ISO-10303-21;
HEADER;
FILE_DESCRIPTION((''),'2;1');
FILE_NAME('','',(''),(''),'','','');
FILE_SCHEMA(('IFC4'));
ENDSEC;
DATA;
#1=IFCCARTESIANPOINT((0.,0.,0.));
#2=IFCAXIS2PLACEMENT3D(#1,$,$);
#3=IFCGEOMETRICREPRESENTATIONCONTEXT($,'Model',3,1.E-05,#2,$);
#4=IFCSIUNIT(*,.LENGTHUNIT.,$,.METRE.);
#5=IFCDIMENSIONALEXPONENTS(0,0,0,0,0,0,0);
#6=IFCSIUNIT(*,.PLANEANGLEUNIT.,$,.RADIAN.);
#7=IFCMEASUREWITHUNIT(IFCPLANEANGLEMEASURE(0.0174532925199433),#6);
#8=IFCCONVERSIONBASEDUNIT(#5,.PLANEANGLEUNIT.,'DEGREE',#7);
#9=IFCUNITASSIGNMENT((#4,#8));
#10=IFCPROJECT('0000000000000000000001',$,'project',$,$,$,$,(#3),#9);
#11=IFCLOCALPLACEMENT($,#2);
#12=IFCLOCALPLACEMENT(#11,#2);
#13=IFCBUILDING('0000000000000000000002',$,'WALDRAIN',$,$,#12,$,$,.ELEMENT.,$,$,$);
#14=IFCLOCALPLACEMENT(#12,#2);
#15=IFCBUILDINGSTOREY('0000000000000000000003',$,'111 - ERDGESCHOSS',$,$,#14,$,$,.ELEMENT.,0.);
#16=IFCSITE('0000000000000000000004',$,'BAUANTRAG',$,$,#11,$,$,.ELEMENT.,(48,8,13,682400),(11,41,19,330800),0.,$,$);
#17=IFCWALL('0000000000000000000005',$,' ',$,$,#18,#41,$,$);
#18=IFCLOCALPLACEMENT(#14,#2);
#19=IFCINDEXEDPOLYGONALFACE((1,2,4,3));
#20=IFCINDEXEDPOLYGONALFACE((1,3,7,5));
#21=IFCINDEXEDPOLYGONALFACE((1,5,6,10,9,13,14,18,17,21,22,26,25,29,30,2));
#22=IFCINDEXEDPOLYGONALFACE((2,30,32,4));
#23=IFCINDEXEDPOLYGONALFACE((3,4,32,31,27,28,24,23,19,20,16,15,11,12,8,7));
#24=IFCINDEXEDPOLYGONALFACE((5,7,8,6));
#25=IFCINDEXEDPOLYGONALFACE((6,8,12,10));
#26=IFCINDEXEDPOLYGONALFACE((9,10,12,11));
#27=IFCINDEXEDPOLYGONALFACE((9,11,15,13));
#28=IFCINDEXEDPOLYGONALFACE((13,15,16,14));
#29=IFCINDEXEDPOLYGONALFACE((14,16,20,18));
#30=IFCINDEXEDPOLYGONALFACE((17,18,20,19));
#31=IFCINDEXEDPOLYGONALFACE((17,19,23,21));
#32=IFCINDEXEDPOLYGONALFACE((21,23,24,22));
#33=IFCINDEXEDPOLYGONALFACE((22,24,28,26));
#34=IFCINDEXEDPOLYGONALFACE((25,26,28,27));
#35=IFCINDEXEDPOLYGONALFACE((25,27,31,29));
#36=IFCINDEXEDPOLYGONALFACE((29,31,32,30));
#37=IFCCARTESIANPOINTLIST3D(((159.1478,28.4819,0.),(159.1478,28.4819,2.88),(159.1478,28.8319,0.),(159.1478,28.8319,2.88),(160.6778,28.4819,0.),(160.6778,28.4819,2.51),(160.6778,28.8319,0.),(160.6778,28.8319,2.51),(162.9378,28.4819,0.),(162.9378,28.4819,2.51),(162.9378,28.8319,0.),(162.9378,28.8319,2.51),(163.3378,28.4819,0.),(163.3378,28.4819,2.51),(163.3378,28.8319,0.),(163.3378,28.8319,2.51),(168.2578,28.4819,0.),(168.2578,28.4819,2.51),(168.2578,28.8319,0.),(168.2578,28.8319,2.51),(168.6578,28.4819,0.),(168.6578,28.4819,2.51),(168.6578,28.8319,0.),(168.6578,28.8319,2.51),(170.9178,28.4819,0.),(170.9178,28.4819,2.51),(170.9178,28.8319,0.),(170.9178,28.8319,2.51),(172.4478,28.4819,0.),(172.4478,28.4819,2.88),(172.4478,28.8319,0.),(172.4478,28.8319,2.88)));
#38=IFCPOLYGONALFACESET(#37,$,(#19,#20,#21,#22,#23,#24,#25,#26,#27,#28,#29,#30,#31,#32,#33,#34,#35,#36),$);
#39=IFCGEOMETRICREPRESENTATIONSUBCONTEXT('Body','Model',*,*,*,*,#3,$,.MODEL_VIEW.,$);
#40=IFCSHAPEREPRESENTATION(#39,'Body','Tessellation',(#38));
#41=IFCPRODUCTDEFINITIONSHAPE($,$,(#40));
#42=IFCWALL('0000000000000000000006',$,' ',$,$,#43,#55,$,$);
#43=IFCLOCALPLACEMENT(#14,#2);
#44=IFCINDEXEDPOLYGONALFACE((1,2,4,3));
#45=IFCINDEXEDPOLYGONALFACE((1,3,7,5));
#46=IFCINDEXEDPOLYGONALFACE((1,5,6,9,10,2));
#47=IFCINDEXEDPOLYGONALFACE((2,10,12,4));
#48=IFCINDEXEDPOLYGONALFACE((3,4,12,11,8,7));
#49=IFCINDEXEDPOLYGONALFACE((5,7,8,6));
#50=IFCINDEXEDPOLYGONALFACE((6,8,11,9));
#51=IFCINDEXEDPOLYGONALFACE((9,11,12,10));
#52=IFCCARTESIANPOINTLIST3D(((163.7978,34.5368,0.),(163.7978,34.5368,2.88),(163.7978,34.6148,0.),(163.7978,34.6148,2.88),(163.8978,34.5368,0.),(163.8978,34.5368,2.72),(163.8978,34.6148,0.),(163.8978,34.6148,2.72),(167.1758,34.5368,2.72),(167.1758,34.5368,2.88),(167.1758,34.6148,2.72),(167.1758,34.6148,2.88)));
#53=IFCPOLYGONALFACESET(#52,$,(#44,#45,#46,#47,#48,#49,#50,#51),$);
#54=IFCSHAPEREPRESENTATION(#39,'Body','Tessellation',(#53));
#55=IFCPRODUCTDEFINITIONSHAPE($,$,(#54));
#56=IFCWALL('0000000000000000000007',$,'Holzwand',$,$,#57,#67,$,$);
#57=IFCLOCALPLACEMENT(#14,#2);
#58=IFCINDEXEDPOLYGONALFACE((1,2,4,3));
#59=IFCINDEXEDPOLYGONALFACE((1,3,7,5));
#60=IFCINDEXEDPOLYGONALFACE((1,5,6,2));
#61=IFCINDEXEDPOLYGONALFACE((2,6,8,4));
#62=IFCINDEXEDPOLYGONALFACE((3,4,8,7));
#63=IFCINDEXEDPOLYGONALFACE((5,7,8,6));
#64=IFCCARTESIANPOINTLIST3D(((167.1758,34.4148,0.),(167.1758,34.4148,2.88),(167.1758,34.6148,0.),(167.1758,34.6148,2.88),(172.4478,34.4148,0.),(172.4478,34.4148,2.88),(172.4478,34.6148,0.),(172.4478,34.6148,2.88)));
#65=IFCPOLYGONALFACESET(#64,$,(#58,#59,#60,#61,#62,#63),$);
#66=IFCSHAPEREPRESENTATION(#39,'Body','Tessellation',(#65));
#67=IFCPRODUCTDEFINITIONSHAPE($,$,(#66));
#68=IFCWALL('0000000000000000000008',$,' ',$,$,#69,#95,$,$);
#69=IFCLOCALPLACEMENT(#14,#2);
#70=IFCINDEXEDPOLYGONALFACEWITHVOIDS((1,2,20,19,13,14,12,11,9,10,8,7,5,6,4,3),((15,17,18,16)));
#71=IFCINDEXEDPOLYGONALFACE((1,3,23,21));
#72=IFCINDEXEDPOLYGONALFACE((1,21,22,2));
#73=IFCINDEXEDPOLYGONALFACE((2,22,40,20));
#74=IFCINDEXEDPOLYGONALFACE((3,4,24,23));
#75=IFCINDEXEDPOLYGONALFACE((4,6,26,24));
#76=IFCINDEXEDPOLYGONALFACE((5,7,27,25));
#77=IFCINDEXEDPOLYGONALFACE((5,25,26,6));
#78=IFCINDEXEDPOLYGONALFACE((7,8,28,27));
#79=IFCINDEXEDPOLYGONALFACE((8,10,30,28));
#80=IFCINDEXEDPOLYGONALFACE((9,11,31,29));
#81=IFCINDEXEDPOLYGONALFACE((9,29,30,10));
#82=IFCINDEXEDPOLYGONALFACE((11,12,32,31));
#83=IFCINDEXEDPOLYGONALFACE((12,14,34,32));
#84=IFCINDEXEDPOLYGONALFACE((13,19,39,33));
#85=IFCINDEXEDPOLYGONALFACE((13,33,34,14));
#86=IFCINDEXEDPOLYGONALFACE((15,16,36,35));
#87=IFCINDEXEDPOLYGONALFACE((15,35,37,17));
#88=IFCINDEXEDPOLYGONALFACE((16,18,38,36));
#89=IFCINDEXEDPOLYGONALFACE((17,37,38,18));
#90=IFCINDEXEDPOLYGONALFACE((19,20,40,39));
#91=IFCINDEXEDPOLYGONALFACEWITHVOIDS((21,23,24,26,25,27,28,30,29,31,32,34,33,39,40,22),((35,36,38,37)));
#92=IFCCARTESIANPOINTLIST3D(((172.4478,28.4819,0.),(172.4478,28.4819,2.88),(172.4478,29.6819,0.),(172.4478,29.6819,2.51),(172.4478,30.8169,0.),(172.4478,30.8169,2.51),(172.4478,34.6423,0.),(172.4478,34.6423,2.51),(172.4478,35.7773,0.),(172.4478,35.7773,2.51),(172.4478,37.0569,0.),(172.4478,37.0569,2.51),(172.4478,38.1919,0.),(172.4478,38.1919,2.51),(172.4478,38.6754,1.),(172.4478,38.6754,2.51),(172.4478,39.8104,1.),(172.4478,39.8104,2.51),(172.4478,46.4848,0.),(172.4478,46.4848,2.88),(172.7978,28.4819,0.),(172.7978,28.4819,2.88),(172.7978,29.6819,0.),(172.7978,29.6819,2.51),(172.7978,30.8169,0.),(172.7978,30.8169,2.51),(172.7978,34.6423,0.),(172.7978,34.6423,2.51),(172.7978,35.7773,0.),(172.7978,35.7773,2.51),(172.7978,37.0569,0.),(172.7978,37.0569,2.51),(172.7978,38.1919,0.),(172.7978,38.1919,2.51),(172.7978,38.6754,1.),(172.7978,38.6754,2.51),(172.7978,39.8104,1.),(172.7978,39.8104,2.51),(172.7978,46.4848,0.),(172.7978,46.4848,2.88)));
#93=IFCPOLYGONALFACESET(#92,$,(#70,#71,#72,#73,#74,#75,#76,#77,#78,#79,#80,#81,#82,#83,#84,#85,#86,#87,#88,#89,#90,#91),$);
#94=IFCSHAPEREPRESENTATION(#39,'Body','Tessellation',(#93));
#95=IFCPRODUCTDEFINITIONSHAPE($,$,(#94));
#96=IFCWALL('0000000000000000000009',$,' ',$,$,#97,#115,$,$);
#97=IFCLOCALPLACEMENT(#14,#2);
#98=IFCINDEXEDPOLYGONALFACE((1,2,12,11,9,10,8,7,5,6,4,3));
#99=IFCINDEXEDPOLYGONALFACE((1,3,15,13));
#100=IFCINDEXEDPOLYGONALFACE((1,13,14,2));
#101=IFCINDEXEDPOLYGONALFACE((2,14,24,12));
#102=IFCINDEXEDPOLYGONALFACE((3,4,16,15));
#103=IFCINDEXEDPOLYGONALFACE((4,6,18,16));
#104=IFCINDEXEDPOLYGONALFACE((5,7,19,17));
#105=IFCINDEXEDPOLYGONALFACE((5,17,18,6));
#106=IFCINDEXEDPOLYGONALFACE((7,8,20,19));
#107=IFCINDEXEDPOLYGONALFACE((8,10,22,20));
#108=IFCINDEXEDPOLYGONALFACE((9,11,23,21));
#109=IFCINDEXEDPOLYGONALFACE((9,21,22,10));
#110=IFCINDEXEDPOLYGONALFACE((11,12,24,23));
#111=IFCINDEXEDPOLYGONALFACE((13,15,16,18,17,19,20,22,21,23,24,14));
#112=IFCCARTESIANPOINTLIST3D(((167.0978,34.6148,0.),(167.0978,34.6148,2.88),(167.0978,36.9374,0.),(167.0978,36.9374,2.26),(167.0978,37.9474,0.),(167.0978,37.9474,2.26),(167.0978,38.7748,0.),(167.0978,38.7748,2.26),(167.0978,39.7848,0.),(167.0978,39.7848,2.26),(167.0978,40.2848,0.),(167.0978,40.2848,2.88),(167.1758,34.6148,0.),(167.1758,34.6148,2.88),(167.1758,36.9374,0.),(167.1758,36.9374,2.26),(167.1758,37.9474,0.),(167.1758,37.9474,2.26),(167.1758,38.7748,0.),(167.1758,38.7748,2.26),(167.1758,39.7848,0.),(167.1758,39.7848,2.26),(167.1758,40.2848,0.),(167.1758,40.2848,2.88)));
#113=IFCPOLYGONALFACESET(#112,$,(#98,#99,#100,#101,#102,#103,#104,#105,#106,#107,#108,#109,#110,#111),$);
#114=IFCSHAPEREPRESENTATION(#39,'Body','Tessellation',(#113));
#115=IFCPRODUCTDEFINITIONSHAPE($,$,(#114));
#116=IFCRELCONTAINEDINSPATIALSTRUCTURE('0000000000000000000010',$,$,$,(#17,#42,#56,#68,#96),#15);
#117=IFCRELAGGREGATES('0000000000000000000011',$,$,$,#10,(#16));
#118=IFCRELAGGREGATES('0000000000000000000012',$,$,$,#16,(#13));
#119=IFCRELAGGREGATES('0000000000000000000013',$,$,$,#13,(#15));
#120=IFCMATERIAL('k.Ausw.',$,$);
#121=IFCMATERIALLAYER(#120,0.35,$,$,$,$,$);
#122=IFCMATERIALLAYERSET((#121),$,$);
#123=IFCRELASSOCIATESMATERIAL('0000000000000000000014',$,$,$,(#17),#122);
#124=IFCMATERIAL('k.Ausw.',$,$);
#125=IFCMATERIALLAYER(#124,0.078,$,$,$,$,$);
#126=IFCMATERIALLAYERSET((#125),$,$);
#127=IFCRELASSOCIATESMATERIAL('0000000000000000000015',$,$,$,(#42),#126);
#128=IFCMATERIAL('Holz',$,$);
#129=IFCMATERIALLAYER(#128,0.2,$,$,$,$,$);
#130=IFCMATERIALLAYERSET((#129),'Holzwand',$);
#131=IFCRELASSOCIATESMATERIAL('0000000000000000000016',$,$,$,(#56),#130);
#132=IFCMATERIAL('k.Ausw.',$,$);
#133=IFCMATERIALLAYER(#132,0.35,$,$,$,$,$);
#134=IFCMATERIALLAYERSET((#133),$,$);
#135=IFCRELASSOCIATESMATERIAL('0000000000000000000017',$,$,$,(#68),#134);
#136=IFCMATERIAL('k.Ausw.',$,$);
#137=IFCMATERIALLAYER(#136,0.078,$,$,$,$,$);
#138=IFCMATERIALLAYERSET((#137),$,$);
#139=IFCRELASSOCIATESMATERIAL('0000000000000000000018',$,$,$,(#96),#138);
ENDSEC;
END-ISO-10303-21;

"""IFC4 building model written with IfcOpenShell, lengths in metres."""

from ifc_helpers import new_model, entity, si_unit, converted_unit, frame, frame_2d, origin, origin_with_axes, place, context, subcontext, project, spatial, polyline, rectangle, outline, extrude, material, layer, layer_set, layer_usage, element, save


model = new_model("IFC4")

# Units and contexts
model_context = context("Model", 3, precision=1e-05, world=origin())
body_context = subcontext(model_context, "Body", "Model", "MODEL_VIEW")
ifc_project = project(units=[si_unit("LENGTHUNIT", "METRE"), converted_unit("PLANEANGLEUNIT", "DEGREE", entity("IfcPlaneAngleMeasure", 0.0174532925199433), si_unit("PLANEANGLEUNIT", "RADIAN"), dimensions=[0, 0, 0, 0, 0, 0, 0])], contexts=[model_context])

# Site, building, storey
site_placement = place(None, origin())
site = spatial("IfcSite", under=ifc_project, at=site_placement, Name="BAUANTRAG", CompositionType="ELEMENT", RefLatitude=(48, 8, 13, 682400), RefLongitude=(11, 41, 19, 330800), RefElevation=0.0)
building_placement = place(site_placement, origin())
building = spatial("IfcBuilding", under=site, at=building_placement, Name="WALDRAIN", CompositionType="ELEMENT")
storey_placement = place(building_placement, origin())
storey = spatial("IfcBuildingStorey", under=building, at=storey_placement, Name="111 - ERDGESCHOSS", CompositionType="ELEMENT", Elevation=0.0)

# Wall, openings
ifc_material_1 = material(Name="k.Ausw.")
ifc_layer_1 = layer(ifc_material_1, 0.35)
ifc_layer_set_1 = layer_set([ifc_layer_1])
ifc_layer_usage_1 = layer_usage(ifc_layer_set_1, "AXIS2", "POSITIVE", 0.0)
wall_1_placement = place(storey_placement, frame((159.1478, 28.4819, 0.0)))
wall_1 = element("IfcWall", 1, at=wall_1_placement, inside=storey, material=ifc_layer_usage_1, Name=" ", context=body_context, shape_type="SweptSolid", body=[
    extrude(rectangle(XDim=13.3, YDim=0.35, at=frame_2d((6.65, 0.175), x_axis=(1.0, 0.0))), origin_with_axes(), (0.0, 0.0, 1.0), 2.88),
])
opening_1_placement = place(wall_1_placement, frame((1.53, 0.0, 0.0), z_axis=(0.0, 1.0, 0.0), x_axis=(0.0, 0.0, 1.0)))
element("IfcOpeningElement", 2, at=opening_1_placement, cuts=wall_1, ObjectType="Opening", context=body_context, shape_type="SweptSolid", body=[
    extrude(outline(polyline([(0.0, 2.26), (2.51, 2.26), (2.51, 0.0), (0.0, 0.0), (0.0, 2.26)])), origin_with_axes(), (0.0, 0.0, 1.0), 0.35),
])
opening_2_placement = place(wall_1_placement, frame((4.19, 0.0, 0.0), z_axis=(0.0, 1.0, 0.0), x_axis=(0.0, 0.0, 1.0)))
element("IfcOpeningElement", 3, at=opening_2_placement, cuts=wall_1, ObjectType="Opening", context=body_context, shape_type="SweptSolid", body=[
    extrude(outline(polyline([(0.0, 4.92), (2.51, 4.92), (2.51, 0.0), (0.0, 0.0), (0.0, 4.92)])), origin_with_axes(), (0.0, 0.0, 1.0), 0.35),
])
opening_3_placement = place(wall_1_placement, frame((9.51, 0.0, 0.0), z_axis=(0.0, 1.0, 0.0), x_axis=(0.0, 0.0, 1.0)))
element("IfcOpeningElement", 4, at=opening_3_placement, cuts=wall_1, ObjectType="Opening", context=body_context, shape_type="SweptSolid", body=[
    extrude(outline(polyline([(0.0, 2.26), (2.51, 2.26), (2.51, 0.0), (0.0, 0.0), (0.0, 2.26)])), origin_with_axes(), (0.0, 0.0, 1.0), 0.35),
])

# Wall, opening
ifc_material_2 = material(Name="k.Ausw.")
ifc_layer_2 = layer(ifc_material_2, 0.078)
ifc_layer_set_2 = layer_set([ifc_layer_2])
ifc_layer_usage_2 = layer_usage(ifc_layer_set_2, "AXIS2", "POSITIVE", 0.0)
wall_2_placement = place(storey_placement, frame((163.7978, 34.5368, 0.0)))
wall_2 = element("IfcWall", 5, at=wall_2_placement, inside=storey, material=ifc_layer_usage_2, Name=" ", context=body_context, shape_type="SweptSolid", body=[
    extrude(rectangle(XDim=3.378, YDim=0.078, at=frame_2d((1.689, 0.039), x_axis=(1.0, 0.0))), origin_with_axes(), (0.0, 0.0, 1.0), 2.88),
])
opening_4_placement = place(wall_2_placement, frame((0.1, 0.0, 0.0), z_axis=(0.0, 1.0, 0.0), x_axis=(0.0, 0.0, 1.0)))
element("IfcOpeningElement", 6, at=opening_4_placement, cuts=wall_2, ObjectType="Opening", context=body_context, shape_type="SweptSolid", body=[
    extrude(outline(polyline([(0.0, 3.278), (2.72, 3.278), (2.72, 0.0), (0.0, 0.0), (0.0, 3.278)])), origin_with_axes(), (0.0, 0.0, 1.0), 0.078),
])

# Wall
ifc_material_3 = material(Name="Holz")
ifc_layer_3 = layer(ifc_material_3, 0.2)
ifc_layer_set_3 = layer_set([ifc_layer_3], Name="Holzwand")
ifc_layer_usage_3 = layer_usage(ifc_layer_set_3, "AXIS2", "POSITIVE", 0.0)
wall_3_placement = place(storey_placement, frame((167.1758, 34.4148, 0.0)))
element("IfcWall", 7, at=wall_3_placement, inside=storey, material=ifc_layer_usage_3, Name="Holzwand", context=body_context, shape_type="SweptSolid", body=[
    extrude(rectangle(XDim=5.272, YDim=0.2, at=frame_2d((2.636, 0.1), x_axis=(1.0, 0.0))), origin_with_axes(), (0.0, 0.0, 1.0), 2.88),
])

# Walls, openings
ifc_material_4 = material(Name="k.Ausw.")
ifc_layer_4 = layer(ifc_material_4, 0.35)
ifc_layer_set_4 = layer_set([ifc_layer_4])
ifc_layer_usage_4 = layer_usage(ifc_layer_set_4, "AXIS2", "POSITIVE", 0.0)
wall_4_placement = place(storey_placement, frame((172.7978, 28.4819, 0.0), z_axis=(0.0, 0.0, 1.0), x_axis=(0.0, 1.0, 0.0)))
wall_4 = element("IfcWall", 8, at=wall_4_placement, inside=storey, material=ifc_layer_usage_4, Name=" ", context=body_context, shape_type="SweptSolid", body=[
    extrude(rectangle(XDim=18.0029, YDim=0.35, at=frame_2d((9.0014, 0.175), x_axis=(1.0, 0.0))), origin_with_axes(), (0.0, 0.0, 1.0), 2.88),
])
opening_5_placement = place(wall_4_placement, frame((10.1935, 0.0, 1.0), z_axis=(0.0, 1.0, 0.0), x_axis=(0.0, 0.0, 1.0)))
element("IfcOpeningElement", 9, at=opening_5_placement, cuts=wall_4, ObjectType="Opening", context=body_context, shape_type="SweptSolid", body=[
    extrude(outline(polyline([(0.0, 1.135), (1.51, 1.135), (1.51, 0.0), (0.0, 0.0), (0.0, 1.135)])), origin_with_axes(), (0.0, 0.0, 1.0), 0.35),
])
opening_6_placement = place(wall_4_placement, frame((1.2, 0.0, 0.0), z_axis=(0.0, 1.0, 0.0), x_axis=(0.0, 0.0, 1.0)))
element("IfcOpeningElement", 10, at=opening_6_placement, cuts=wall_4, ObjectType="Opening", context=body_context, shape_type="SweptSolid", body=[
    extrude(outline(polyline([(0.0, 1.135), (2.51, 1.135), (2.51, 0.0), (0.0, 0.0), (0.0, 1.135)])), origin_with_axes(), (0.0, 0.0, 1.0), 0.35),
])
opening_7_placement = place(wall_4_placement, frame((6.1604, 0.0, 0.0), z_axis=(0.0, 1.0, 0.0), x_axis=(0.0, 0.0, 1.0)))
element("IfcOpeningElement", 11, at=opening_7_placement, cuts=wall_4, ObjectType="Opening", context=body_context, shape_type="SweptSolid", body=[
    extrude(outline(polyline([(0.0, 1.135), (2.51, 1.135), (2.51, 0.0), (0.0, 0.0), (0.0, 1.135)])), origin_with_axes(), (0.0, 0.0, 1.0), 0.35),
])
opening_8_placement = place(wall_4_placement, frame((8.575, 0.0, 0.0), z_axis=(0.0, 1.0, 0.0), x_axis=(0.0, 0.0, 1.0)))
element("IfcOpeningElement", 12, at=opening_8_placement, cuts=wall_4, ObjectType="Opening", context=body_context, shape_type="SweptSolid", body=[
    extrude(outline(polyline([(0.0, 1.135), (2.51, 1.135), (2.51, 0.0), (0.0, 0.0), (0.0, 1.135)])), origin_with_axes(), (0.0, 0.0, 1.0), 0.35),
])
ifc_material_5 = material(Name="k.Ausw.")
ifc_layer_5 = layer(ifc_material_5, 0.078)
ifc_layer_set_5 = layer_set([ifc_layer_5])
ifc_layer_usage_5 = layer_usage(ifc_layer_set_5, "AXIS2", "POSITIVE", 0.0)
wall_5_placement = place(storey_placement, frame((167.1758, 34.6148, 0.0), z_axis=(0.0, 0.0, 1.0), x_axis=(0.0, 1.0, 0.0)))
wall_5 = element("IfcWall", 13, at=wall_5_placement, inside=storey, material=ifc_layer_usage_5, Name=" ", context=body_context, shape_type="SweptSolid", body=[
    extrude(rectangle(XDim=5.67, YDim=0.078, at=frame_2d((2.835, 0.039), x_axis=(1.0, 0.0))), origin_with_axes(), (0.0, 0.0, 1.0), 2.88),
])
opening_9_placement = place(wall_5_placement, frame((4.16, 0.0, 0.0), z_axis=(0.0, 1.0, 0.0), x_axis=(0.0, 0.0, 1.0)))
element("IfcOpeningElement", 14, at=opening_9_placement, cuts=wall_5, ObjectType="Opening", context=body_context, shape_type="SweptSolid", body=[
    extrude(outline(polyline([(0.0, 1.01), (2.26, 1.01), (2.26, 0.0), (0.0, 0.0), (0.0, 1.01)])), origin_with_axes(), (0.0, 0.0, 1.0), 0.078),
])
opening_10_placement = place(wall_5_placement, frame((2.3226, 0.0, 0.0), z_axis=(0.0, 1.0, 0.0), x_axis=(0.0, 0.0, 1.0)))
element("IfcOpeningElement", 15, at=opening_10_placement, cuts=wall_5, ObjectType="Opening", context=body_context, shape_type="SweptSolid", body=[
    extrude(outline(polyline([(0.0, 1.01), (2.26, 1.01), (2.26, 0.0), (0.0, 0.0), (0.0, 1.01)])), origin_with_axes(), (0.0, 0.0, 1.0), 0.078),
])

save(model, "model.ifc")
